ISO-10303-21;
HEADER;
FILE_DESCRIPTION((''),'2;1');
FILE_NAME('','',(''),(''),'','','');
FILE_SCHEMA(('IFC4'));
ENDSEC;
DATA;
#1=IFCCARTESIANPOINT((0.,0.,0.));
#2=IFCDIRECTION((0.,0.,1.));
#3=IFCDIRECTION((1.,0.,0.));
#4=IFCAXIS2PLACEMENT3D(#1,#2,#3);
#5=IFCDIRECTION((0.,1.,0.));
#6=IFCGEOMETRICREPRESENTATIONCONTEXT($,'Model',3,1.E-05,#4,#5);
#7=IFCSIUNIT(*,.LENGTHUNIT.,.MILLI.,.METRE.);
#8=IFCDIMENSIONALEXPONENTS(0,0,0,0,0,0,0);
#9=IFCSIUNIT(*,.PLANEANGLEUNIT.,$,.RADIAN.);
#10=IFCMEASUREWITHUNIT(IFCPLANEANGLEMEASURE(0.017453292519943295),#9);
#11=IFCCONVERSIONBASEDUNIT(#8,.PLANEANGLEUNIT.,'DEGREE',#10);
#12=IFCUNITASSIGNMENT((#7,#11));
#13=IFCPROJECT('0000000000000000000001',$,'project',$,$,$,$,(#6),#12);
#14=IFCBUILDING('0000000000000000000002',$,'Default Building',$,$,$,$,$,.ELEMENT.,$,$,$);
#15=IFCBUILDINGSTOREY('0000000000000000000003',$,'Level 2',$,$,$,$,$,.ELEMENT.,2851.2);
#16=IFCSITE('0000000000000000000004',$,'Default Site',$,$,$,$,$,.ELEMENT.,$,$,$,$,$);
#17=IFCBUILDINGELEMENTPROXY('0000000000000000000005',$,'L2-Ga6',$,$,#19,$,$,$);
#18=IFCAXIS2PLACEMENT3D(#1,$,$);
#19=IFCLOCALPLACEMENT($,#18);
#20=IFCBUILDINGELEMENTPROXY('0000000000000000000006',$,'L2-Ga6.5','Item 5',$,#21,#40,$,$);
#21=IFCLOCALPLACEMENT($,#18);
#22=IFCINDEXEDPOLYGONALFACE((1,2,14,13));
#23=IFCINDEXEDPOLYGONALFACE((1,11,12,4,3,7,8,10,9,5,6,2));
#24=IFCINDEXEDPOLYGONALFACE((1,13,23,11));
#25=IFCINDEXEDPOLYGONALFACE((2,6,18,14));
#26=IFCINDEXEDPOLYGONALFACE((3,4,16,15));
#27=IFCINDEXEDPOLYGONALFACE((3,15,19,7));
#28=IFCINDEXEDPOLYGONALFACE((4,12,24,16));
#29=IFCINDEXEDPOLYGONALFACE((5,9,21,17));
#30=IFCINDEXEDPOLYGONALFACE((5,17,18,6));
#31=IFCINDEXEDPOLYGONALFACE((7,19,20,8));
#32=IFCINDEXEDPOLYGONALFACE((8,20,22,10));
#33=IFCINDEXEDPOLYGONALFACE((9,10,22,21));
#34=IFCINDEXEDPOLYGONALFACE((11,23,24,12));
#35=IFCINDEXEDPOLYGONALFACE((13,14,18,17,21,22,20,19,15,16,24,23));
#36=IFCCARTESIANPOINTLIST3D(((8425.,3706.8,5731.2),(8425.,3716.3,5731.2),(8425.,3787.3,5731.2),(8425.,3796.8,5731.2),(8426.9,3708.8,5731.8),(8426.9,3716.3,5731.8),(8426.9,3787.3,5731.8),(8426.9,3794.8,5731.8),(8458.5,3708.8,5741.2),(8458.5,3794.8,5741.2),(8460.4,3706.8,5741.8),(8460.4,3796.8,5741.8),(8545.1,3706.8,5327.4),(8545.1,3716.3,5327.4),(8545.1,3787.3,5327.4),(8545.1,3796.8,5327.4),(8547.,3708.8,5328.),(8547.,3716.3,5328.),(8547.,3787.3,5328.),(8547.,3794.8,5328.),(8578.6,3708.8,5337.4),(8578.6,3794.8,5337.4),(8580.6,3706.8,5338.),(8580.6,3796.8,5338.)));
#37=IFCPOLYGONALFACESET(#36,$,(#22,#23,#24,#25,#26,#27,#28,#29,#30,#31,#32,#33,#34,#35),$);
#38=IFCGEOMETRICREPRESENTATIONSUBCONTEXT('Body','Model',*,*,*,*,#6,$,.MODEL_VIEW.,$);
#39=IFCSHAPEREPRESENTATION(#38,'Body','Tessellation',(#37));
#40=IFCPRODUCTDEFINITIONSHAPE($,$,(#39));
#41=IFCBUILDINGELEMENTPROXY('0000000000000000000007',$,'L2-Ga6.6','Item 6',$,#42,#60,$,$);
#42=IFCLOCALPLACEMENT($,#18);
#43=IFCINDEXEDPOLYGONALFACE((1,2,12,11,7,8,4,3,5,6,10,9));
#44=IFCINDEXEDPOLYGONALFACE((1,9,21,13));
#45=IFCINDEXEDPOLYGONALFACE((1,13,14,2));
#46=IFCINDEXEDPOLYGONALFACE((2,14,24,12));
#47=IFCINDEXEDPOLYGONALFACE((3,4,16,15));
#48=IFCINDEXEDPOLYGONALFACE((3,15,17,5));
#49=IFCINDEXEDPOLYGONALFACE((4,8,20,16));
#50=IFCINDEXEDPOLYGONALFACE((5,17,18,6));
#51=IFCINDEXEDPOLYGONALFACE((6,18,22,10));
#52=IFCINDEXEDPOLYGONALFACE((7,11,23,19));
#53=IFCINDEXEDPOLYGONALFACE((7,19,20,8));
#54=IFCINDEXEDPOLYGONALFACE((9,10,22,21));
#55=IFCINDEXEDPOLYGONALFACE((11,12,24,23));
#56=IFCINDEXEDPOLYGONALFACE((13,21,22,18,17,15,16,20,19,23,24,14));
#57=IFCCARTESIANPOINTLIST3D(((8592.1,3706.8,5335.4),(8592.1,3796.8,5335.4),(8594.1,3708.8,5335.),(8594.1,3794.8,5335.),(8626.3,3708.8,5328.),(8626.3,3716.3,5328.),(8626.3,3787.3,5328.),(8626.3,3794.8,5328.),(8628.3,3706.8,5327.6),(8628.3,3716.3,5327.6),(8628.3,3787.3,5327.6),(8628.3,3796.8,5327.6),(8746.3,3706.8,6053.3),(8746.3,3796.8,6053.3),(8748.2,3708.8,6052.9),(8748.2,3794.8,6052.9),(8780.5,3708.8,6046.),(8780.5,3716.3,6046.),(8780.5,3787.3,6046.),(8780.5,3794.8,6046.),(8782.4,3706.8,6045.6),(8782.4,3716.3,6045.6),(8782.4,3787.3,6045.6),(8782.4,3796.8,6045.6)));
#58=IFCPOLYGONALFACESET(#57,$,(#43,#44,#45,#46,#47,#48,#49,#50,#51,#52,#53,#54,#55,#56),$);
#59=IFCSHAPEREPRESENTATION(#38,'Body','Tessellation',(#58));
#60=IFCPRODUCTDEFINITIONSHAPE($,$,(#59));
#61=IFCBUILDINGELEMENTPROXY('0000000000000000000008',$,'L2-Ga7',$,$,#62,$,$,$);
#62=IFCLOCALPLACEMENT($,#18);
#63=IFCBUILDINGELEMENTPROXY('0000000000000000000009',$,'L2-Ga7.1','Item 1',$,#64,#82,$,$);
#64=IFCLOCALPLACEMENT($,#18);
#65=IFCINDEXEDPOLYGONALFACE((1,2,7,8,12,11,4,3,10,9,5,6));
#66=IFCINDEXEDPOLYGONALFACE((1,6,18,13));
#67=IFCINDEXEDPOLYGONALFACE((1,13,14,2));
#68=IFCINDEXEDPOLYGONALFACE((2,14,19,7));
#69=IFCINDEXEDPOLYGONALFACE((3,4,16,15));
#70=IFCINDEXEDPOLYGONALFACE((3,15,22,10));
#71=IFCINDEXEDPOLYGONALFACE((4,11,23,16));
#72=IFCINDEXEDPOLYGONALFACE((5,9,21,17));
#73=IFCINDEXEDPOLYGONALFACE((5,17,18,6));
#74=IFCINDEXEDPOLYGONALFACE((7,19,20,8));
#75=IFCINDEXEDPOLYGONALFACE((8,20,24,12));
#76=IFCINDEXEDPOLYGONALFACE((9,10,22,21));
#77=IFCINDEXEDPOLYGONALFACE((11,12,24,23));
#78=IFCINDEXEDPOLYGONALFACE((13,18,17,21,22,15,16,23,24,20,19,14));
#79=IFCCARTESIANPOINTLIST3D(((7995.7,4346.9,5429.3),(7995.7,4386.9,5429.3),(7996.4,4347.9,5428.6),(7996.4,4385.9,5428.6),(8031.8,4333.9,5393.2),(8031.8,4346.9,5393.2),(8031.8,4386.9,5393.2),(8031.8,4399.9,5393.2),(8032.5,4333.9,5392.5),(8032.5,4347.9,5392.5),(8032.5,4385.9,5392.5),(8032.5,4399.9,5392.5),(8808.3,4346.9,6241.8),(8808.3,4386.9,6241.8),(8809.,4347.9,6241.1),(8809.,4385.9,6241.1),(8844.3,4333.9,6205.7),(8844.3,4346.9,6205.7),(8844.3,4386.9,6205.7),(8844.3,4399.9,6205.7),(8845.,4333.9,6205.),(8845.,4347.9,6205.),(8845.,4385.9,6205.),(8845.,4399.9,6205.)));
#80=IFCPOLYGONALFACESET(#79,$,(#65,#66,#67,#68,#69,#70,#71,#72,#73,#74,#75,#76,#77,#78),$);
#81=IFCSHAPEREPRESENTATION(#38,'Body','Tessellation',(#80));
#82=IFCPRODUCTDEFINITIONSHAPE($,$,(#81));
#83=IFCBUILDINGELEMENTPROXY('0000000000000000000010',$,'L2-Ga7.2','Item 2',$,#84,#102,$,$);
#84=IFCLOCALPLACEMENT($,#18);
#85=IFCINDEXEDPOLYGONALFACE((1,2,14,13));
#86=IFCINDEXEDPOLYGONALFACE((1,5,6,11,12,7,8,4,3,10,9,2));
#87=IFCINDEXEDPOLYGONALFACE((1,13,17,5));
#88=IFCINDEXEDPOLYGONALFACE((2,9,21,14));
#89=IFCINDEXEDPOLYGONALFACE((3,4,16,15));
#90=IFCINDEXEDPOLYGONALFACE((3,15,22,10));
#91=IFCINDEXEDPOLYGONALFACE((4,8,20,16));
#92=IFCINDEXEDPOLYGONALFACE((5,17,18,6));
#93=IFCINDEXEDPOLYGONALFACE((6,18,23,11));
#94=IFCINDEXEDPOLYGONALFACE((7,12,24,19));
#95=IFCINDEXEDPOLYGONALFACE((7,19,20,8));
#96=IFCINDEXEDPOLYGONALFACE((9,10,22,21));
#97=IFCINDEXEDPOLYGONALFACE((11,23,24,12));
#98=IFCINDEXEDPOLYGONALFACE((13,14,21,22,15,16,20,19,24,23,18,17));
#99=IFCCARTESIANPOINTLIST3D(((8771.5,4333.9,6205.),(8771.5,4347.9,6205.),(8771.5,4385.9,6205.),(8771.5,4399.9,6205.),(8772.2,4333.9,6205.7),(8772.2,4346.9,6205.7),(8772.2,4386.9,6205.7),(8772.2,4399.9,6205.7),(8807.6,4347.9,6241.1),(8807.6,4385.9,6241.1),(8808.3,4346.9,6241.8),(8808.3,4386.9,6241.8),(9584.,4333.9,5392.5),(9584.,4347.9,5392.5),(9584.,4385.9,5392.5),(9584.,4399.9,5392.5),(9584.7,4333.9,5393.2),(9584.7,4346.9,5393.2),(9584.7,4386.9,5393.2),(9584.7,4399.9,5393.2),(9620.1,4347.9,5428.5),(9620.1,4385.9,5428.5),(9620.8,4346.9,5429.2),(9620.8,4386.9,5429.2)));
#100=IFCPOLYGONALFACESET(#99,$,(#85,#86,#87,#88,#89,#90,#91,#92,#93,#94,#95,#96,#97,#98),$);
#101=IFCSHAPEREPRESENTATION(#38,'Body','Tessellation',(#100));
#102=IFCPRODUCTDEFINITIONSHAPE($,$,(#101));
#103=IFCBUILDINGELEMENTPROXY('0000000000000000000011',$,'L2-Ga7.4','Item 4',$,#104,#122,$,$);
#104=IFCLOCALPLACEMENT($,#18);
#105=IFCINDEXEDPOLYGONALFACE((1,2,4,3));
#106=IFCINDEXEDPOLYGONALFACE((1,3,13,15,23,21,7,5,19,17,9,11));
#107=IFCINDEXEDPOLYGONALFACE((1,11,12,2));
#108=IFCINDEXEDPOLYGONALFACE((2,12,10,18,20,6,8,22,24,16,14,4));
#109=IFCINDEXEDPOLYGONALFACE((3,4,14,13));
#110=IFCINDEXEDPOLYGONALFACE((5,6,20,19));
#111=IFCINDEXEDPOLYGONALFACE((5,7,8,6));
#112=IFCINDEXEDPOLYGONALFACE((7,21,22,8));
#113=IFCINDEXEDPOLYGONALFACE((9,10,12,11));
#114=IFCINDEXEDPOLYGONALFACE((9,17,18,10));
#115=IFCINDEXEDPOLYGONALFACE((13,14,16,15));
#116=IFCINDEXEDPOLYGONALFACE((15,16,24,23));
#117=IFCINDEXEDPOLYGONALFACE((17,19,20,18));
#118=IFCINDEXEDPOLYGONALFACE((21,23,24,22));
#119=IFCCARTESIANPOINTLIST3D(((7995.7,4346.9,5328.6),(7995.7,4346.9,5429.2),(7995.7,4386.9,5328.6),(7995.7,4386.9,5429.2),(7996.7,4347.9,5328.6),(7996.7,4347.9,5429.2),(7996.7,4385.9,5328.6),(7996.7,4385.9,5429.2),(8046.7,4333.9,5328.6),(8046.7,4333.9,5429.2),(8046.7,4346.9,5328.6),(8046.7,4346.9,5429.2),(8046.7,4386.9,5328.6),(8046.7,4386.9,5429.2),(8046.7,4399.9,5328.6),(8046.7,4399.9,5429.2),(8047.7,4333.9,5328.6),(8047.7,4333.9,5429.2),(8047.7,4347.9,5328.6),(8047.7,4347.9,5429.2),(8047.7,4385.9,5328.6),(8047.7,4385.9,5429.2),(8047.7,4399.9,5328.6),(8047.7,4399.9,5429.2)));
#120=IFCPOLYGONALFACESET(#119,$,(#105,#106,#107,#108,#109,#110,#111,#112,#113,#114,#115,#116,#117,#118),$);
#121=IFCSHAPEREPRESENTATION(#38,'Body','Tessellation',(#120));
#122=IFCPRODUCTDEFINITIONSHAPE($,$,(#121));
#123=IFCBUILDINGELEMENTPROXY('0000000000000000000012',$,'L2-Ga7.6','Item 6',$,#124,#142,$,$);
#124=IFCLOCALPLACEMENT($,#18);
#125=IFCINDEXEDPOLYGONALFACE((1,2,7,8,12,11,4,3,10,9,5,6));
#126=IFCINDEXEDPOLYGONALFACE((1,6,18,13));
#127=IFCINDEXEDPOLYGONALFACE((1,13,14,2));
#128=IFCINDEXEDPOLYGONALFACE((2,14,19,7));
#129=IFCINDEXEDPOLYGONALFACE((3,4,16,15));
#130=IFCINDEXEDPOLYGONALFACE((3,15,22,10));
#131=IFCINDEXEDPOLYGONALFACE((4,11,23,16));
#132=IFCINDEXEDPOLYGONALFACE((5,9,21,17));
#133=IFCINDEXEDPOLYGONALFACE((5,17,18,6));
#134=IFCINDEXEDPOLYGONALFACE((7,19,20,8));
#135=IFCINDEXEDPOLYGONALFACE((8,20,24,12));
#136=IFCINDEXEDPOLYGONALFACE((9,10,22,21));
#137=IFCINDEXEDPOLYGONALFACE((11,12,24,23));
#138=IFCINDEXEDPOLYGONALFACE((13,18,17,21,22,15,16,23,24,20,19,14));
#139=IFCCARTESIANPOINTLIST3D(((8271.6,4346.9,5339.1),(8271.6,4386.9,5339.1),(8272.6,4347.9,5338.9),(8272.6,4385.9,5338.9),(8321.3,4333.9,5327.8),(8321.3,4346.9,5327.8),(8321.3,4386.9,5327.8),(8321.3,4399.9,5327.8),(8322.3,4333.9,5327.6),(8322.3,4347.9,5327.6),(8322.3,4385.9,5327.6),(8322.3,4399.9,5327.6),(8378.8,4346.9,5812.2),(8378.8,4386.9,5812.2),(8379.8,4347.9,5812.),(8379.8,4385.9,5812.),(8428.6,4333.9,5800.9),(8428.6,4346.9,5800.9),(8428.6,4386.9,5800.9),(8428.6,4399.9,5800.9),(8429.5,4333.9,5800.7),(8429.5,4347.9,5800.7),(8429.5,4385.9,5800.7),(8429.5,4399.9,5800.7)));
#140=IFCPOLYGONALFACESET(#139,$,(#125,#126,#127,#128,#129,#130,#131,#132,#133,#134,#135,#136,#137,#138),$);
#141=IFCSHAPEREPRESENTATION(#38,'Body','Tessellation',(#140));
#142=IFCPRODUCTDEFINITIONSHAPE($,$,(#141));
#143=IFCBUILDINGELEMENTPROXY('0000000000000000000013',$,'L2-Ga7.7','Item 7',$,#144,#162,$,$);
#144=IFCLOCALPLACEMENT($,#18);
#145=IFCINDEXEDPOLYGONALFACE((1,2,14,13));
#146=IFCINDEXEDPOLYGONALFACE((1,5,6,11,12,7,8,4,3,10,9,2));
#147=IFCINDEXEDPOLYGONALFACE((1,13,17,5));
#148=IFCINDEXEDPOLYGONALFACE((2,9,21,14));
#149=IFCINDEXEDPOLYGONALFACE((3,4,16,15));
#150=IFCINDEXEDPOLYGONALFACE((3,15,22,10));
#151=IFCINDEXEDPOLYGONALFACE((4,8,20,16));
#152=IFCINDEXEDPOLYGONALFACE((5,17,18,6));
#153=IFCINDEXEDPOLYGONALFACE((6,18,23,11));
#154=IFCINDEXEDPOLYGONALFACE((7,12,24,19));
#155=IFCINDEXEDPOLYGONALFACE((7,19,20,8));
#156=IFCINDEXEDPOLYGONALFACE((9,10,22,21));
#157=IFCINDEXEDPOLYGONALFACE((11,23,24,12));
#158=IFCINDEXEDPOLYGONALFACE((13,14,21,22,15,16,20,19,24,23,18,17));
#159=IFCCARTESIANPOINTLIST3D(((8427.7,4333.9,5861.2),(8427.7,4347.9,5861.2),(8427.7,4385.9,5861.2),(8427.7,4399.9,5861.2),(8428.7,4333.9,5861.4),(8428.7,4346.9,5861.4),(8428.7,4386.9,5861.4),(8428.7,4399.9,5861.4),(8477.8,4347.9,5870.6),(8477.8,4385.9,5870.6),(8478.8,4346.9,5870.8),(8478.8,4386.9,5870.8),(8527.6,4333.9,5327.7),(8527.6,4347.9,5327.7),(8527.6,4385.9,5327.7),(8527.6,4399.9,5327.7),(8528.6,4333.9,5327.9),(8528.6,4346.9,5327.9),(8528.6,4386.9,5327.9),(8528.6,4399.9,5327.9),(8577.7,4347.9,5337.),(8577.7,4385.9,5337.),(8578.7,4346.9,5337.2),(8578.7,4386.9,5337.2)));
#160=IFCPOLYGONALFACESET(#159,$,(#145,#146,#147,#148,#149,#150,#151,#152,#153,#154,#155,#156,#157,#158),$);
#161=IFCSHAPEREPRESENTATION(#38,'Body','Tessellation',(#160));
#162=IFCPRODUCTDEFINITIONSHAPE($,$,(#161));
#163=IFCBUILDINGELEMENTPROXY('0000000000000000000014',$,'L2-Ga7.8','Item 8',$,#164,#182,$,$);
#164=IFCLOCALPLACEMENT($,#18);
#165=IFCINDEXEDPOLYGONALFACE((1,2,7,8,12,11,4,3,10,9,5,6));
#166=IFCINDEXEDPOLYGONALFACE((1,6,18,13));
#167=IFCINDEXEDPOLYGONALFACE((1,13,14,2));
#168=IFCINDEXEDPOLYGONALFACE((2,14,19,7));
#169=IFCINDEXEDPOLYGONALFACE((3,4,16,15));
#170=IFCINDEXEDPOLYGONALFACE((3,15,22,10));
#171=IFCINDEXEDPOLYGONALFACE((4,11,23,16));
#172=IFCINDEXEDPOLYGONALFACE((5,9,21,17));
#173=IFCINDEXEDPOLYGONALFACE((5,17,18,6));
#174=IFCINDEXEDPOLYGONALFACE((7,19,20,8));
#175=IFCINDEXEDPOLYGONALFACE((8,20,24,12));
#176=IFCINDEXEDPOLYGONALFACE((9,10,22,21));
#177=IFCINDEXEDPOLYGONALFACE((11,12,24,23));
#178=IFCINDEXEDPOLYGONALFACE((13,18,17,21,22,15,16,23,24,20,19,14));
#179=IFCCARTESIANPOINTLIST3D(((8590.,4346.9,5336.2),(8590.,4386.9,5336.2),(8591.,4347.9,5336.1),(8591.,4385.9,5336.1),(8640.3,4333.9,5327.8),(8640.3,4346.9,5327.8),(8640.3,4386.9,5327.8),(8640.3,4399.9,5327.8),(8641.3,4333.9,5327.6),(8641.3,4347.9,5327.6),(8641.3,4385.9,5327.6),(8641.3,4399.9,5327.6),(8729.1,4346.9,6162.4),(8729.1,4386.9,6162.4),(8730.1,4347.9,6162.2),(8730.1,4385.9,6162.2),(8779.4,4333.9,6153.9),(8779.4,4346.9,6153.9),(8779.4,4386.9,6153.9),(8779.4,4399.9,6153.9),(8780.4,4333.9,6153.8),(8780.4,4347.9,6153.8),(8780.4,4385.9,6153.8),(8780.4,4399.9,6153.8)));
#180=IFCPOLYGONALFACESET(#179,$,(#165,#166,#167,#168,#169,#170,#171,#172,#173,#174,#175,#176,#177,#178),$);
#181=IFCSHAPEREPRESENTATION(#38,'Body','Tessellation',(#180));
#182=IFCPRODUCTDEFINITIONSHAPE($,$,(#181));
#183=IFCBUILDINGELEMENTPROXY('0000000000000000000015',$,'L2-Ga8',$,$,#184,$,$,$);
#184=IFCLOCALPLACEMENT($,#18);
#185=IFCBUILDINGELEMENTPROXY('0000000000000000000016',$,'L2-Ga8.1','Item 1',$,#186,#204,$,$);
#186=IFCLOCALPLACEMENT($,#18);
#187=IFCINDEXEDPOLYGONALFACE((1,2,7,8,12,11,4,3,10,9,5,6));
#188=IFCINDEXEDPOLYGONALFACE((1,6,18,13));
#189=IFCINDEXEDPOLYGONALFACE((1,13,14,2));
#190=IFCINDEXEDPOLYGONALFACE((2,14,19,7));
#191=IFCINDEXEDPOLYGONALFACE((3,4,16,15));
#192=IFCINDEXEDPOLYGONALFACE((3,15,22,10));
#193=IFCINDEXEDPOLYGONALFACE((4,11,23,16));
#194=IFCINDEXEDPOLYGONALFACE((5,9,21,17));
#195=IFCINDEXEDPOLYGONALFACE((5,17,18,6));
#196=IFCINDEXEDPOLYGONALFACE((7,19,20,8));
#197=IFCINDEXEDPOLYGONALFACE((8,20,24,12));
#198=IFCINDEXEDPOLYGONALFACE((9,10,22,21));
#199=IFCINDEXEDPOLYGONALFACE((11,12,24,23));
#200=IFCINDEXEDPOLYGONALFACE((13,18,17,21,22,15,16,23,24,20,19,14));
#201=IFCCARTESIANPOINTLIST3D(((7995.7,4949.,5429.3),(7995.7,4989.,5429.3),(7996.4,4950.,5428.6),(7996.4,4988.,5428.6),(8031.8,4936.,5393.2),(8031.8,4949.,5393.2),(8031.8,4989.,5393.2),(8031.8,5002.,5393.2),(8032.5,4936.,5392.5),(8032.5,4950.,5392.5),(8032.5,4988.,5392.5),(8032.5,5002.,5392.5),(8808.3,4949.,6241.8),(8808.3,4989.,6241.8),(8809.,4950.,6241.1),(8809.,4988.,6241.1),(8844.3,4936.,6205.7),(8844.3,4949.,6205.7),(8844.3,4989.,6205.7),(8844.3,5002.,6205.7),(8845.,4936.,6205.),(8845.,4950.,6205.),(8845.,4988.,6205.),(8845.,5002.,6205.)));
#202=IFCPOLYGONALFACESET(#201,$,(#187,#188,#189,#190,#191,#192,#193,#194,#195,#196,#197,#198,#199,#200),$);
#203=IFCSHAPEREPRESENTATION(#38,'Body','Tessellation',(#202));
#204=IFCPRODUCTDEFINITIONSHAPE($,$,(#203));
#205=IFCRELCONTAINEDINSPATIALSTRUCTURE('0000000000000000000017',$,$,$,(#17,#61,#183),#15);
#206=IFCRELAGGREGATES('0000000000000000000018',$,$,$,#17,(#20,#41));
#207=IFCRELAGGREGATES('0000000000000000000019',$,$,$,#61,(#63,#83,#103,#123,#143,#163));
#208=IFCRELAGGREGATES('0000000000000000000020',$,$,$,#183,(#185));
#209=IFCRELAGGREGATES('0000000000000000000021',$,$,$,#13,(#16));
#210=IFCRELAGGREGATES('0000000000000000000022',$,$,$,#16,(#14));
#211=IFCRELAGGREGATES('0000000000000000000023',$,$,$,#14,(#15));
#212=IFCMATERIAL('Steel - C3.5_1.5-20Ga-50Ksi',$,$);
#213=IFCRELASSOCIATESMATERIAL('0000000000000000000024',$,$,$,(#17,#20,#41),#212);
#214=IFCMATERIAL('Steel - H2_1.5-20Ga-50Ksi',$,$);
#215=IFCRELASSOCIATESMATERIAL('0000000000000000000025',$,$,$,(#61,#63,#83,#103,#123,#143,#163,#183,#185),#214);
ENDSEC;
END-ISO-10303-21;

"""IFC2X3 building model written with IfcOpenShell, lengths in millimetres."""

from ifc_helpers import new_model, entity, si_unit, converted_unit, direction, frame, origin, origin_with_axes, origin_2d_with_axis, place, context, subcontext, project, spatial, polyline, c_section, outline, extrude, material, element, aggregate, save


model = new_model("IFC2X3")

# Units and contexts
model_context = context("Model", 3, precision=1e-05, world=origin_with_axes(), true_north=direction((0.0, 1.0, 0.0)))
body_context = subcontext(model_context, "Body", "Model", "MODEL_VIEW")
ifc_project = project(units=[si_unit("LENGTHUNIT", "METRE", prefix="MILLI"), converted_unit("PLANEANGLEUNIT", "DEGREE", entity("IfcPlaneAngleMeasure", 0.017453292519943295), si_unit("PLANEANGLEUNIT", "RADIAN"), dimensions=[0, 0, 0, 0, 0, 0, 0])], contexts=[model_context])

# Site, building, storey
site = spatial("IfcSite", under=ifc_project, Name="Default Site", CompositionType="ELEMENT")
building = spatial("IfcBuilding", under=site, Name="Default Building", CompositionType="ELEMENT")
storey = spatial("IfcBuildingStorey", under=building, Name="Level 2", CompositionType="ELEMENT", Elevation=2851.2)

# Shared definitions
ifc_material_1 = material(Name="Steel - C3.5_1.5-20Ga-50Ksi")

# Building element proxies
proxy_1 = element("IfcBuildingElementProxy", 1, inside=storey, material=ifc_material_1, Name="L2-Ga6")
proxy_2_placement = place(None, frame((8442.7, 3751.8, 5736.5), z_axis=(0.285, 0.0, -0.958), x_axis=(-35.46, 0.0, -10.563)))
proxy_2 = element("IfcBuildingElementProxy", 2, at=proxy_2_placement, material=ifc_material_1, Name="L2-Ga6.5", Description="Item 5", context=body_context, shape_type="SweptSolid", body=[
    extrude(c_section(Depth=90.0, Width=37.0, WallThickness=2.0, Girth=9.5, at=origin_2d_with_axis()), origin(), (0.0, 0.0, 1.0), 421.3),
])
proxy_3_placement = place(None, frame((8610.2, 3751.8, 5331.5), z_axis=(0.21, 0.0, 0.978), x_axis=(36.171, 0.0, -7.787)))
proxy_3 = element("IfcBuildingElementProxy", 3, at=proxy_3_placement, material=ifc_material_1, Name="L2-Ga6.6", Description="Item 6", context=body_context, shape_type="SweptSolid", body=[
    extrude(c_section(Depth=90.0, Width=37.0, WallThickness=2.0, Girth=9.5, at=origin_2d_with_axis()), origin(), (0.0, 0.0, 1.0), 734.3),
])
aggregate(proxy_1, [proxy_2, proxy_3])
ifc_material_2 = material(Name="Steel - H2_1.5-20Ga-50Ksi")
proxy_4 = element("IfcBuildingElementProxy", 4, inside=storey, material=ifc_material_2, Name="L2-Ga7")
proxy_5_placement = place(None, frame((8032.5, 4333.9, 5392.5), z_axis=(0.707, 0.0, 0.707), x_axis=(0.0, 40.0, 0.0)))
proxy_5 = element("IfcBuildingElementProxy", 5, at=proxy_5_placement, material=ifc_material_2, Name="L2-Ga7.1", Description="Item 1", context=body_context, shape_type="SweptSolid", body=[
    extrude(outline(polyline([(0.0, 0.0), (14.0, 0.0), (14.0, 51.0), (52.0, 51.0), (52.0, 0.0), (66.0, 0.0), (66.0, 1.0), (53.0, 1.0), (53.0, 52.0), (13.0, 52.0), (13.0, 1.0), (0.0, 1.0), (0.0, 0.0)])), origin(), (0.0, 0.0, 1.0), 1149.1),
])
proxy_6_placement = place(None, frame((8771.5, 4333.9, 6205.0), z_axis=(0.707, 0.0, -0.707), x_axis=(0.0, 40.0, 0.0)))
proxy_6 = element("IfcBuildingElementProxy", 6, at=proxy_6_placement, material=ifc_material_2, Name="L2-Ga7.2", Description="Item 2", context=body_context, shape_type="SweptSolid", body=[
    extrude(outline(polyline([(0.0, 0.0), (14.0, 0.0), (14.0, 51.0), (52.0, 51.0), (52.0, 0.0), (66.0, 0.0), (66.0, 1.0), (53.0, 1.0), (53.0, 52.0), (13.0, 52.0), (13.0, 1.0), (0.0, 1.0), (0.0, 0.0)])), origin(), (0.0, 0.0, 1.0), 1149.1),
])
proxy_7_placement = place(None, frame((8047.7, 4333.9, 5328.6), z_axis=(0.0, 0.0, 1.0), x_axis=(0.0, 40.0, 0.0)))
proxy_7 = element("IfcBuildingElementProxy", 7, at=proxy_7_placement, material=ifc_material_2, Name="L2-Ga7.4", Description="Item 4", context=body_context, shape_type="SweptSolid", body=[
    extrude(outline(polyline([(0.0, 0.0), (14.0, 0.0), (14.0, 51.0), (52.0, 51.0), (52.0, 0.0), (66.0, 0.0), (66.0, 1.0), (53.0, 1.0), (53.0, 52.0), (13.0, 52.0), (13.0, 1.0), (0.0, 1.0), (0.0, 0.0)])), origin(), (0.0, 0.0, 1.0), 100.6),
])
proxy_8_placement = place(None, frame((8322.3, 4333.9, 5327.6), z_axis=(0.221, 0.0, 0.975), x_axis=(0.0, 40.0, 0.0)))
proxy_8 = element("IfcBuildingElementProxy", 8, at=proxy_8_placement, material=ifc_material_2, Name="L2-Ga7.6", Description="Item 6", context=body_context, shape_type="SweptSolid", body=[
    extrude(outline(polyline([(0.0, 0.0), (14.0, 0.0), (14.0, 51.0), (52.0, 51.0), (52.0, 0.0), (66.0, 0.0), (66.0, 1.0), (53.0, 1.0), (53.0, 52.0), (13.0, 52.0), (13.0, 1.0), (0.0, 1.0), (0.0, 0.0)])), origin(), (0.0, 0.0, 1.0), 485.1),
])
proxy_9_placement = place(None, frame((8427.7, 4333.9, 5861.2), z_axis=(0.184, 0.0, -0.983), x_axis=(0.0, 40.0, 0.0)))
proxy_9 = element("IfcBuildingElementProxy", 9, at=proxy_9_placement, material=ifc_material_2, Name="L2-Ga7.7", Description="Item 7", context=body_context, shape_type="SweptSolid", body=[
    extrude(outline(polyline([(0.0, 0.0), (14.0, 0.0), (14.0, 51.0), (52.0, 51.0), (52.0, 0.0), (66.0, 0.0), (66.0, 1.0), (53.0, 1.0), (53.0, 52.0), (13.0, 52.0), (13.0, 1.0), (0.0, 1.0), (0.0, 0.0)])), origin(), (0.0, 0.0, 1.0), 542.8),
])
proxy_10_placement = place(None, frame((8641.3, 4333.9, 5327.6), z_axis=(0.166, 0.0, 0.986), x_axis=(0.0, 40.0, 0.0)))
proxy_10 = element("IfcBuildingElementProxy", 10, at=proxy_10_placement, material=ifc_material_2, Name="L2-Ga7.8", Description="Item 8", context=body_context, shape_type="SweptSolid", body=[
    extrude(outline(polyline([(0.0, 0.0), (14.0, 0.0), (14.0, 51.0), (52.0, 51.0), (52.0, 0.0), (66.0, 0.0), (66.0, 1.0), (53.0, 1.0), (53.0, 52.0), (13.0, 52.0), (13.0, 1.0), (0.0, 1.0), (0.0, 0.0)])), origin(), (0.0, 0.0, 1.0), 837.8),
])
aggregate(proxy_4, [proxy_5, proxy_6, proxy_7, proxy_8, proxy_9, proxy_10])
proxy_11 = element("IfcBuildingElementProxy", 11, inside=storey, material=ifc_material_2, Name="L2-Ga8")
proxy_12_placement = place(None, frame((8032.5, 4936.0, 5392.5), z_axis=(0.707, 0.0, 0.707), x_axis=(0.0, 40.0, 0.0)))
proxy_12 = element("IfcBuildingElementProxy", 12, at=proxy_12_placement, material=ifc_material_2, Name="L2-Ga8.1", Description="Item 1", context=body_context, shape_type="SweptSolid", body=[
    extrude(outline(polyline([(0.0, 0.0), (14.0, 0.0), (14.0, 51.0), (52.0, 51.0), (52.0, 0.0), (66.0, 0.0), (66.0, 1.0), (53.0, 1.0), (53.0, 52.0), (13.0, 52.0), (13.0, 1.0), (0.0, 1.0), (0.0, 0.0)])), origin(), (0.0, 0.0, 1.0), 1149.1),
])
aggregate(proxy_11, [proxy_12])

save(model, "model.ifc")
